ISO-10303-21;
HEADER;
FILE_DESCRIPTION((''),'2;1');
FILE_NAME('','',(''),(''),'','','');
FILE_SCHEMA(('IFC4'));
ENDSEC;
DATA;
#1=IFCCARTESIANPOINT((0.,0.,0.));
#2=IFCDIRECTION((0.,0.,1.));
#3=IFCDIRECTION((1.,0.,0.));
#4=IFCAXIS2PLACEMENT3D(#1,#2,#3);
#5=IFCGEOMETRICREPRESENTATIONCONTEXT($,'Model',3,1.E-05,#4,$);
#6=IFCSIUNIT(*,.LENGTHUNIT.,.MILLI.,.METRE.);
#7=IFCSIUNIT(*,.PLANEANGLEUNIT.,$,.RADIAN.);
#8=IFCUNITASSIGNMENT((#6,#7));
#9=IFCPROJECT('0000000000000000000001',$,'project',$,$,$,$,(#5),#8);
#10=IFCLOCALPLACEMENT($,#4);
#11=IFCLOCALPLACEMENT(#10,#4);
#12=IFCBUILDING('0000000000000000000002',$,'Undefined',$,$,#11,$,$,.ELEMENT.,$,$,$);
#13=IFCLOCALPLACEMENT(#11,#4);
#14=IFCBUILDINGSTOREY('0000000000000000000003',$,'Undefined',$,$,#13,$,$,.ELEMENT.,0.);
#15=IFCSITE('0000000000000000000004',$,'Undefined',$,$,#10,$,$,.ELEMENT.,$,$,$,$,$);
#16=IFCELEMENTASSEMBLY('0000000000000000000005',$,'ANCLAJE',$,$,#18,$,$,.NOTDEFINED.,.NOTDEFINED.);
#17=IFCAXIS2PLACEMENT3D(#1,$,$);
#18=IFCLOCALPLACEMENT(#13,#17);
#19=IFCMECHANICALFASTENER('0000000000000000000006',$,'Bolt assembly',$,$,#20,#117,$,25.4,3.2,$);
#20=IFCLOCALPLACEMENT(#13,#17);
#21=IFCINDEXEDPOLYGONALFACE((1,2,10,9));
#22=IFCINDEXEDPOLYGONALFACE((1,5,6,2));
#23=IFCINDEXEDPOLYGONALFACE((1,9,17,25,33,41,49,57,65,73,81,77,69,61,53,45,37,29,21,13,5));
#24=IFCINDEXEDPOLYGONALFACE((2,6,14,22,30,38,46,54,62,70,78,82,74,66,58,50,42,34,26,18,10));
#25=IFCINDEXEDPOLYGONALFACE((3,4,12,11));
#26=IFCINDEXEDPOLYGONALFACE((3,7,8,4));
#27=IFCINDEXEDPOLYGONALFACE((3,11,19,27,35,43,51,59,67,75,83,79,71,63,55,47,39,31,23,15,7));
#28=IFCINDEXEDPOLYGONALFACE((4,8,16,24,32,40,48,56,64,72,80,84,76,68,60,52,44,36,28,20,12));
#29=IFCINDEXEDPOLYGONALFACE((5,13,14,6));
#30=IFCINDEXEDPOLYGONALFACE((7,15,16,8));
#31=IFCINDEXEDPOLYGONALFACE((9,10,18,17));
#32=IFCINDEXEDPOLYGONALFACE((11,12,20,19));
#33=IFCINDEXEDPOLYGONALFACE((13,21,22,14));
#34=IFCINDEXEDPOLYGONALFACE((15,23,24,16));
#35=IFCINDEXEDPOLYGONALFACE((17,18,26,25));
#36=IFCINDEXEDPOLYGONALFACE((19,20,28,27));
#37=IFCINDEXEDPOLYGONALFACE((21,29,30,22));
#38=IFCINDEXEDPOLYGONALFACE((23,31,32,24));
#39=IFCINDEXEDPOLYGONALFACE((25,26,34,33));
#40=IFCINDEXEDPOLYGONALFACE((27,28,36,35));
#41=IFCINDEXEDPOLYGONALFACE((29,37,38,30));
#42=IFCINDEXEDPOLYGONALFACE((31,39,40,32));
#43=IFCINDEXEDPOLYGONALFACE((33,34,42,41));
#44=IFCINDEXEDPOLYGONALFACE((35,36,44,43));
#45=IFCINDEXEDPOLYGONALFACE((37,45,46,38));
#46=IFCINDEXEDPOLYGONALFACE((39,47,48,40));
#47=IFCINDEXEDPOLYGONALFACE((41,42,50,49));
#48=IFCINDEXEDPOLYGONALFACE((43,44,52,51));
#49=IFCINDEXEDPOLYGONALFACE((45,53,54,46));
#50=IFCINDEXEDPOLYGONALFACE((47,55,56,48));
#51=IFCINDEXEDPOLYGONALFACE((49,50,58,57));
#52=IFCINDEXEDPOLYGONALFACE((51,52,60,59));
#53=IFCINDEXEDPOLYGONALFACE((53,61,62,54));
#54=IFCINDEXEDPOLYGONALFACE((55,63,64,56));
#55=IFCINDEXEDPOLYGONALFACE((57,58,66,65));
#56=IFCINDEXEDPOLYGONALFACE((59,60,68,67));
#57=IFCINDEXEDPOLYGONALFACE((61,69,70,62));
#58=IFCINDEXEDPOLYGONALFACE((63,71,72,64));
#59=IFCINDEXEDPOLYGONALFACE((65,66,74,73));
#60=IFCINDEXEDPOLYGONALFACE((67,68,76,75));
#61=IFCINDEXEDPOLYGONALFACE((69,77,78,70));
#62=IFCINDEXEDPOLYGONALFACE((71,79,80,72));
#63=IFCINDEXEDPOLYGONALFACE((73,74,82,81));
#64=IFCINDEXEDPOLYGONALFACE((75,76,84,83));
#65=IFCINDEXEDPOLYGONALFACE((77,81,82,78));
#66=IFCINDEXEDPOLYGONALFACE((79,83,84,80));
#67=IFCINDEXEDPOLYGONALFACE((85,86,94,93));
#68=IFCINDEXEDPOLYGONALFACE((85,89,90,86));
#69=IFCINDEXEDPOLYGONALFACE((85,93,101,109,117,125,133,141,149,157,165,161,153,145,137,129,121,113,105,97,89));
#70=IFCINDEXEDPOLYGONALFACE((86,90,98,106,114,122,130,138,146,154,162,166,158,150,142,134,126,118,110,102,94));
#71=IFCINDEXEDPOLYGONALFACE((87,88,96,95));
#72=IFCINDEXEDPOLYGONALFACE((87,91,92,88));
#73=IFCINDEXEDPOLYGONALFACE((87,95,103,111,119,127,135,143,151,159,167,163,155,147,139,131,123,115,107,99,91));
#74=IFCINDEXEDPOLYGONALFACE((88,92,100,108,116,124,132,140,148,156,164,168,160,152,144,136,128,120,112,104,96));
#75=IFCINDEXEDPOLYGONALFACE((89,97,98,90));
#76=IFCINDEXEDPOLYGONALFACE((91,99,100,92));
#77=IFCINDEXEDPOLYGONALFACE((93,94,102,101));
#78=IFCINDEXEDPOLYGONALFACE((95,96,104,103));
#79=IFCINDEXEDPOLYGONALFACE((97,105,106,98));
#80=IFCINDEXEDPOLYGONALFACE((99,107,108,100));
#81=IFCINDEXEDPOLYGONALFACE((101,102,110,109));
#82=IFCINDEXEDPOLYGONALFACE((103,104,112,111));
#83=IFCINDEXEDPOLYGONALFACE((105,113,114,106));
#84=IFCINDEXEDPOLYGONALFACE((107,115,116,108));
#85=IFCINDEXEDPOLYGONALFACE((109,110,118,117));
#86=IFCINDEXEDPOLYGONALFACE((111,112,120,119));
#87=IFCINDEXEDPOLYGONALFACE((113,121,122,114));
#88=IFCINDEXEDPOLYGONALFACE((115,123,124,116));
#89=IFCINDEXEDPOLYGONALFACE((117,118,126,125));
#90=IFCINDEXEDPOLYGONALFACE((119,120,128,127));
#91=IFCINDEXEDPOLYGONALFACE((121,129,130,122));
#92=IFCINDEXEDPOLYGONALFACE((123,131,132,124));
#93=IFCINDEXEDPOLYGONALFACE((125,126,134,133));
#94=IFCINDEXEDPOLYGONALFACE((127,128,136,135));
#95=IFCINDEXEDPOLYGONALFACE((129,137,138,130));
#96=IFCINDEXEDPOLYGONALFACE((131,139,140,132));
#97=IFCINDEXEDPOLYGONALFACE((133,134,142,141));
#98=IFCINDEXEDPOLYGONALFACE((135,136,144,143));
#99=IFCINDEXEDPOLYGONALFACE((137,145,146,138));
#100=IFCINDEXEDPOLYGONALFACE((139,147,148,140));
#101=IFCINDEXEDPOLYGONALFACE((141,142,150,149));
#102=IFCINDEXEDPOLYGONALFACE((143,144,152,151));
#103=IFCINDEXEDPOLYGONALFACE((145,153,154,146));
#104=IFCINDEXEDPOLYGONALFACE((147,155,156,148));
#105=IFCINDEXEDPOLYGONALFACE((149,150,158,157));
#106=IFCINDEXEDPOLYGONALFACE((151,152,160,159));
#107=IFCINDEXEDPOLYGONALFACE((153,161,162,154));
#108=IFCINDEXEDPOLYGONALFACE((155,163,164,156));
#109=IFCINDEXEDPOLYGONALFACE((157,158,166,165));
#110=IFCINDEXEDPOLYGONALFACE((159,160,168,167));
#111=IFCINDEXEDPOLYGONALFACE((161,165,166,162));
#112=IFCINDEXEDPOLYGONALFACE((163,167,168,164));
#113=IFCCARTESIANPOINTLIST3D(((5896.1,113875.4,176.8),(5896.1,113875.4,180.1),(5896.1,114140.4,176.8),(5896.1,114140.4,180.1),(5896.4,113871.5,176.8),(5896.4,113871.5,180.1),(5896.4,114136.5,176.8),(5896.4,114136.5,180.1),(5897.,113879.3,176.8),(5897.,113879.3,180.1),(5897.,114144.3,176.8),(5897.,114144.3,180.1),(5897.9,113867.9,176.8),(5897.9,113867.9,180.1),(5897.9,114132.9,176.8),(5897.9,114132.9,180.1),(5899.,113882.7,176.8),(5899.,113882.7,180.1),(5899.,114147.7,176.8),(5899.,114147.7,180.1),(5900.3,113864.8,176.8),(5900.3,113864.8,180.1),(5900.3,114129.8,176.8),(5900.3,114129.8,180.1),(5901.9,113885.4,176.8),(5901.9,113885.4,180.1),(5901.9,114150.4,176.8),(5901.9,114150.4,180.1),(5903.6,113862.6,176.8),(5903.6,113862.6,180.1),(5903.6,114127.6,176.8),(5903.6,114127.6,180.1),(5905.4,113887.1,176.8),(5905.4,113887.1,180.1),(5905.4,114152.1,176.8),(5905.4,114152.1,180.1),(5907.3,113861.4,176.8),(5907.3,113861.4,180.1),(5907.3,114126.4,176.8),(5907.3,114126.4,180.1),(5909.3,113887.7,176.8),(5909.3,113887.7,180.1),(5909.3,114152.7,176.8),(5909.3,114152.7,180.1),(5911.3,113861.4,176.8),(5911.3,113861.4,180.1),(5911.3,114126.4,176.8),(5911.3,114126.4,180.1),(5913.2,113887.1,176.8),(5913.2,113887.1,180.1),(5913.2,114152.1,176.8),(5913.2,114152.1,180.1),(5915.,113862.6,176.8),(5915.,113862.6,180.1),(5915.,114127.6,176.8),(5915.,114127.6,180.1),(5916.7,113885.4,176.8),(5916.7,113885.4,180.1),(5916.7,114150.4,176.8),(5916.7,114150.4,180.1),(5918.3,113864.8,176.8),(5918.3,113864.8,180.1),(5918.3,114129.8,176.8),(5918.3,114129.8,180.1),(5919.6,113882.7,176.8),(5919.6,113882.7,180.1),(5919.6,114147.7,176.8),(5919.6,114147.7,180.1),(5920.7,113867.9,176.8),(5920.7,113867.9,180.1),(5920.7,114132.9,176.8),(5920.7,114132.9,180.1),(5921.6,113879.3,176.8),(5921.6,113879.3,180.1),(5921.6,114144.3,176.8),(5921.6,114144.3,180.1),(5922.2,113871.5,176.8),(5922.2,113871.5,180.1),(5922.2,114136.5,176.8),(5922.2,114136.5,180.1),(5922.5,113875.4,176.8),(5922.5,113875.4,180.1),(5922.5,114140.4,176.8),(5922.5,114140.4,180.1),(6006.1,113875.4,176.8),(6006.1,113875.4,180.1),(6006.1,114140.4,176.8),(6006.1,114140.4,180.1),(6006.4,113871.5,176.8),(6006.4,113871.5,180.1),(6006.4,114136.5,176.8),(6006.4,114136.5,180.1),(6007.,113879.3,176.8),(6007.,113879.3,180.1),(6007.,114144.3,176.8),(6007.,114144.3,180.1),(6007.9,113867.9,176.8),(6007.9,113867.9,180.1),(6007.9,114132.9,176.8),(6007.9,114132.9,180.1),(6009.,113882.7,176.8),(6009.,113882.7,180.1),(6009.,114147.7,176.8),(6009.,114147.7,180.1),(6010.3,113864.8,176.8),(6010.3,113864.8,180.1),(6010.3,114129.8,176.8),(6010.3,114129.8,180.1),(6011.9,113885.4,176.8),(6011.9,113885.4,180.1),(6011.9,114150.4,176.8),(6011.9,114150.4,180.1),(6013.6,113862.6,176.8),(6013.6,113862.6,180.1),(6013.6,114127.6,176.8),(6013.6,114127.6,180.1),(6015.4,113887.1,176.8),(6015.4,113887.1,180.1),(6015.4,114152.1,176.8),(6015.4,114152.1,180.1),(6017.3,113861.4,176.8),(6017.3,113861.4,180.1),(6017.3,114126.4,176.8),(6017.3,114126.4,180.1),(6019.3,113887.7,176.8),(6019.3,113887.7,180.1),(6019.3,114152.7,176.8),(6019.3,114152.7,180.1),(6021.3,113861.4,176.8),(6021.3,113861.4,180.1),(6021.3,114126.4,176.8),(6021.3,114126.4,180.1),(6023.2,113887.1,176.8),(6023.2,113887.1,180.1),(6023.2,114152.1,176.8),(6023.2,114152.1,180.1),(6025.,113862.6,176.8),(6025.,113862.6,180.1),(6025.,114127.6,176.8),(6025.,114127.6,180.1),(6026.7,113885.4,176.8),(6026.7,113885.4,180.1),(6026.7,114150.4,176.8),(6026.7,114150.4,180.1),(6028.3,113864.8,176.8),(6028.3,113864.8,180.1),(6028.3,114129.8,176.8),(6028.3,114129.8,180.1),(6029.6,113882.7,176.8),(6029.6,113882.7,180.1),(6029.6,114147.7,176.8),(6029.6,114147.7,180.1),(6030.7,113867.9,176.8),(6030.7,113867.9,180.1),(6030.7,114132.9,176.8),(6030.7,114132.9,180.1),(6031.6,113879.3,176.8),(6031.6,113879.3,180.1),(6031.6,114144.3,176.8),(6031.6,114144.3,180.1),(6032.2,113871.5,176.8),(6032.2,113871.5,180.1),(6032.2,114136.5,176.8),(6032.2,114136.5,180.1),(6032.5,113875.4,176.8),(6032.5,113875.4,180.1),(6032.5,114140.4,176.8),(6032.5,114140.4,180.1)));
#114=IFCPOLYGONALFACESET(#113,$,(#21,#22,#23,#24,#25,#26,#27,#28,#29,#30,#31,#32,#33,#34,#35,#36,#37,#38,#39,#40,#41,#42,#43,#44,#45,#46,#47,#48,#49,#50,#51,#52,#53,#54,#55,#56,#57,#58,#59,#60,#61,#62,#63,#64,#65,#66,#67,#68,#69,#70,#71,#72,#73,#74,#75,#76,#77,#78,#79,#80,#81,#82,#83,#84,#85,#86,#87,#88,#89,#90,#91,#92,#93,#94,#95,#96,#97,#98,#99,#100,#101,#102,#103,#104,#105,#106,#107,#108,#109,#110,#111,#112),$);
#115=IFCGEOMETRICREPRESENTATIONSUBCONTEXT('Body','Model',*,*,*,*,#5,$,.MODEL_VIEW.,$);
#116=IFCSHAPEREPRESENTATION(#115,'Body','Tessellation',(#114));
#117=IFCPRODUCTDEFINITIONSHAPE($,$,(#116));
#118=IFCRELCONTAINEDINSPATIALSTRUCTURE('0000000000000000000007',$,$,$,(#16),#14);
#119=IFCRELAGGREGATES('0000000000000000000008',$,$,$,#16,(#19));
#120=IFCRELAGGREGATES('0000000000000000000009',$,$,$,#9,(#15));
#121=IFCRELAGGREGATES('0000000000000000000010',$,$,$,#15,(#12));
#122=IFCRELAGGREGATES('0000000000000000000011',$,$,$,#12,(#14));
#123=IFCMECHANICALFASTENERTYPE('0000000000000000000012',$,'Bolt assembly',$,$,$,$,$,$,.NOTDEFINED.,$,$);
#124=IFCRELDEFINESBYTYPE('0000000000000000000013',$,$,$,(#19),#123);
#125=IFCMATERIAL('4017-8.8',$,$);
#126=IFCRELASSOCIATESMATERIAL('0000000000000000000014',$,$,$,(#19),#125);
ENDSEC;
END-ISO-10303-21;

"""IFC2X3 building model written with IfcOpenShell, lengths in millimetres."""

from ifc_helpers import new_model, si_unit, frame, origin_with_axes, origin_2d_with_axis, place, context, subcontext, project, spatial, circle, extrude, source, transform, mapped, material, type_object, element, aggregate, save


model = new_model("IFC2X3")

# Units and contexts
model_context = context("Model", 3, precision=1e-05, world=origin_with_axes())
body_context = subcontext(model_context, "Body", "Model", "MODEL_VIEW")
ifc_project = project(units=[si_unit("LENGTHUNIT", "METRE", prefix="MILLI"), si_unit("PLANEANGLEUNIT", "RADIAN")], contexts=[model_context])

# Site, building, storey
site_placement = place(None, origin_with_axes())
site = spatial("IfcSite", under=ifc_project, at=site_placement, Name="Undefined", CompositionType="ELEMENT")
building_placement = place(site_placement, origin_with_axes())
building = spatial("IfcBuilding", under=site, at=building_placement, Name="Undefined", CompositionType="ELEMENT")
storey_placement = place(building_placement, origin_with_axes())
storey = spatial("IfcBuildingStorey", under=building, at=storey_placement, Name="Undefined", CompositionType="ELEMENT", Elevation=0.0)

# Element assembly
assembly_1_placement = place(storey_placement, origin_with_axes())
assembly_1 = element("IfcElementAssembly", 1, at=assembly_1_placement, inside=storey, Name="ANCLAJE", AssemblyPlace="NOTDEFINED", PredefinedType="NOTDEFINED")

# Mechanical fastener
ifc_material_1 = material(Name="4017-8.8")
mechanical_fastener_type = type_object("IfcMechanicalFastenerType", Name="Bolt assembly")
shared_shape_1 = source(origin_with_axes(), body_context, "Body", "SweptSolid", [
    extrude(circle(Radius=13.2, at=origin_2d_with_axis()), frame((0.0, -22.2, 0.0), z_axis=(0.0, 1.0, 0.0), x_axis=(1.0, 0.0, 0.0)), (0.0, 0.0, 1.0), 3.3),
])
mechanical_fastener_1_placement = place(assembly_1_placement, frame((5964.3, 113874.5, 199.0), z_axis=(1.0, 0.0, 0.0), x_axis=(0.0, 1.0, 0.0)))
mechanical_fastener_1 = element("IfcMechanicalFastener", 2, at=mechanical_fastener_1_placement, type_object=mechanical_fastener_type, material=ifc_material_1, Name="Bolt assembly", NominalDiameter=25.4, NominalLength=3.2, context=body_context, shape_type="MappedRepresentation", body=[
    mapped(shared_shape_1, transform((0.0, 0.0, -55.0))),
    mapped(shared_shape_1, transform((265.0, 0.0, -55.0))),
    mapped(shared_shape_1, transform((0.0, 0.0, 55.0))),
    mapped(shared_shape_1, transform((265.0, 0.0, 55.0))),
])
aggregate(assembly_1, [mechanical_fastener_1])

save(model, "model.ifc")
